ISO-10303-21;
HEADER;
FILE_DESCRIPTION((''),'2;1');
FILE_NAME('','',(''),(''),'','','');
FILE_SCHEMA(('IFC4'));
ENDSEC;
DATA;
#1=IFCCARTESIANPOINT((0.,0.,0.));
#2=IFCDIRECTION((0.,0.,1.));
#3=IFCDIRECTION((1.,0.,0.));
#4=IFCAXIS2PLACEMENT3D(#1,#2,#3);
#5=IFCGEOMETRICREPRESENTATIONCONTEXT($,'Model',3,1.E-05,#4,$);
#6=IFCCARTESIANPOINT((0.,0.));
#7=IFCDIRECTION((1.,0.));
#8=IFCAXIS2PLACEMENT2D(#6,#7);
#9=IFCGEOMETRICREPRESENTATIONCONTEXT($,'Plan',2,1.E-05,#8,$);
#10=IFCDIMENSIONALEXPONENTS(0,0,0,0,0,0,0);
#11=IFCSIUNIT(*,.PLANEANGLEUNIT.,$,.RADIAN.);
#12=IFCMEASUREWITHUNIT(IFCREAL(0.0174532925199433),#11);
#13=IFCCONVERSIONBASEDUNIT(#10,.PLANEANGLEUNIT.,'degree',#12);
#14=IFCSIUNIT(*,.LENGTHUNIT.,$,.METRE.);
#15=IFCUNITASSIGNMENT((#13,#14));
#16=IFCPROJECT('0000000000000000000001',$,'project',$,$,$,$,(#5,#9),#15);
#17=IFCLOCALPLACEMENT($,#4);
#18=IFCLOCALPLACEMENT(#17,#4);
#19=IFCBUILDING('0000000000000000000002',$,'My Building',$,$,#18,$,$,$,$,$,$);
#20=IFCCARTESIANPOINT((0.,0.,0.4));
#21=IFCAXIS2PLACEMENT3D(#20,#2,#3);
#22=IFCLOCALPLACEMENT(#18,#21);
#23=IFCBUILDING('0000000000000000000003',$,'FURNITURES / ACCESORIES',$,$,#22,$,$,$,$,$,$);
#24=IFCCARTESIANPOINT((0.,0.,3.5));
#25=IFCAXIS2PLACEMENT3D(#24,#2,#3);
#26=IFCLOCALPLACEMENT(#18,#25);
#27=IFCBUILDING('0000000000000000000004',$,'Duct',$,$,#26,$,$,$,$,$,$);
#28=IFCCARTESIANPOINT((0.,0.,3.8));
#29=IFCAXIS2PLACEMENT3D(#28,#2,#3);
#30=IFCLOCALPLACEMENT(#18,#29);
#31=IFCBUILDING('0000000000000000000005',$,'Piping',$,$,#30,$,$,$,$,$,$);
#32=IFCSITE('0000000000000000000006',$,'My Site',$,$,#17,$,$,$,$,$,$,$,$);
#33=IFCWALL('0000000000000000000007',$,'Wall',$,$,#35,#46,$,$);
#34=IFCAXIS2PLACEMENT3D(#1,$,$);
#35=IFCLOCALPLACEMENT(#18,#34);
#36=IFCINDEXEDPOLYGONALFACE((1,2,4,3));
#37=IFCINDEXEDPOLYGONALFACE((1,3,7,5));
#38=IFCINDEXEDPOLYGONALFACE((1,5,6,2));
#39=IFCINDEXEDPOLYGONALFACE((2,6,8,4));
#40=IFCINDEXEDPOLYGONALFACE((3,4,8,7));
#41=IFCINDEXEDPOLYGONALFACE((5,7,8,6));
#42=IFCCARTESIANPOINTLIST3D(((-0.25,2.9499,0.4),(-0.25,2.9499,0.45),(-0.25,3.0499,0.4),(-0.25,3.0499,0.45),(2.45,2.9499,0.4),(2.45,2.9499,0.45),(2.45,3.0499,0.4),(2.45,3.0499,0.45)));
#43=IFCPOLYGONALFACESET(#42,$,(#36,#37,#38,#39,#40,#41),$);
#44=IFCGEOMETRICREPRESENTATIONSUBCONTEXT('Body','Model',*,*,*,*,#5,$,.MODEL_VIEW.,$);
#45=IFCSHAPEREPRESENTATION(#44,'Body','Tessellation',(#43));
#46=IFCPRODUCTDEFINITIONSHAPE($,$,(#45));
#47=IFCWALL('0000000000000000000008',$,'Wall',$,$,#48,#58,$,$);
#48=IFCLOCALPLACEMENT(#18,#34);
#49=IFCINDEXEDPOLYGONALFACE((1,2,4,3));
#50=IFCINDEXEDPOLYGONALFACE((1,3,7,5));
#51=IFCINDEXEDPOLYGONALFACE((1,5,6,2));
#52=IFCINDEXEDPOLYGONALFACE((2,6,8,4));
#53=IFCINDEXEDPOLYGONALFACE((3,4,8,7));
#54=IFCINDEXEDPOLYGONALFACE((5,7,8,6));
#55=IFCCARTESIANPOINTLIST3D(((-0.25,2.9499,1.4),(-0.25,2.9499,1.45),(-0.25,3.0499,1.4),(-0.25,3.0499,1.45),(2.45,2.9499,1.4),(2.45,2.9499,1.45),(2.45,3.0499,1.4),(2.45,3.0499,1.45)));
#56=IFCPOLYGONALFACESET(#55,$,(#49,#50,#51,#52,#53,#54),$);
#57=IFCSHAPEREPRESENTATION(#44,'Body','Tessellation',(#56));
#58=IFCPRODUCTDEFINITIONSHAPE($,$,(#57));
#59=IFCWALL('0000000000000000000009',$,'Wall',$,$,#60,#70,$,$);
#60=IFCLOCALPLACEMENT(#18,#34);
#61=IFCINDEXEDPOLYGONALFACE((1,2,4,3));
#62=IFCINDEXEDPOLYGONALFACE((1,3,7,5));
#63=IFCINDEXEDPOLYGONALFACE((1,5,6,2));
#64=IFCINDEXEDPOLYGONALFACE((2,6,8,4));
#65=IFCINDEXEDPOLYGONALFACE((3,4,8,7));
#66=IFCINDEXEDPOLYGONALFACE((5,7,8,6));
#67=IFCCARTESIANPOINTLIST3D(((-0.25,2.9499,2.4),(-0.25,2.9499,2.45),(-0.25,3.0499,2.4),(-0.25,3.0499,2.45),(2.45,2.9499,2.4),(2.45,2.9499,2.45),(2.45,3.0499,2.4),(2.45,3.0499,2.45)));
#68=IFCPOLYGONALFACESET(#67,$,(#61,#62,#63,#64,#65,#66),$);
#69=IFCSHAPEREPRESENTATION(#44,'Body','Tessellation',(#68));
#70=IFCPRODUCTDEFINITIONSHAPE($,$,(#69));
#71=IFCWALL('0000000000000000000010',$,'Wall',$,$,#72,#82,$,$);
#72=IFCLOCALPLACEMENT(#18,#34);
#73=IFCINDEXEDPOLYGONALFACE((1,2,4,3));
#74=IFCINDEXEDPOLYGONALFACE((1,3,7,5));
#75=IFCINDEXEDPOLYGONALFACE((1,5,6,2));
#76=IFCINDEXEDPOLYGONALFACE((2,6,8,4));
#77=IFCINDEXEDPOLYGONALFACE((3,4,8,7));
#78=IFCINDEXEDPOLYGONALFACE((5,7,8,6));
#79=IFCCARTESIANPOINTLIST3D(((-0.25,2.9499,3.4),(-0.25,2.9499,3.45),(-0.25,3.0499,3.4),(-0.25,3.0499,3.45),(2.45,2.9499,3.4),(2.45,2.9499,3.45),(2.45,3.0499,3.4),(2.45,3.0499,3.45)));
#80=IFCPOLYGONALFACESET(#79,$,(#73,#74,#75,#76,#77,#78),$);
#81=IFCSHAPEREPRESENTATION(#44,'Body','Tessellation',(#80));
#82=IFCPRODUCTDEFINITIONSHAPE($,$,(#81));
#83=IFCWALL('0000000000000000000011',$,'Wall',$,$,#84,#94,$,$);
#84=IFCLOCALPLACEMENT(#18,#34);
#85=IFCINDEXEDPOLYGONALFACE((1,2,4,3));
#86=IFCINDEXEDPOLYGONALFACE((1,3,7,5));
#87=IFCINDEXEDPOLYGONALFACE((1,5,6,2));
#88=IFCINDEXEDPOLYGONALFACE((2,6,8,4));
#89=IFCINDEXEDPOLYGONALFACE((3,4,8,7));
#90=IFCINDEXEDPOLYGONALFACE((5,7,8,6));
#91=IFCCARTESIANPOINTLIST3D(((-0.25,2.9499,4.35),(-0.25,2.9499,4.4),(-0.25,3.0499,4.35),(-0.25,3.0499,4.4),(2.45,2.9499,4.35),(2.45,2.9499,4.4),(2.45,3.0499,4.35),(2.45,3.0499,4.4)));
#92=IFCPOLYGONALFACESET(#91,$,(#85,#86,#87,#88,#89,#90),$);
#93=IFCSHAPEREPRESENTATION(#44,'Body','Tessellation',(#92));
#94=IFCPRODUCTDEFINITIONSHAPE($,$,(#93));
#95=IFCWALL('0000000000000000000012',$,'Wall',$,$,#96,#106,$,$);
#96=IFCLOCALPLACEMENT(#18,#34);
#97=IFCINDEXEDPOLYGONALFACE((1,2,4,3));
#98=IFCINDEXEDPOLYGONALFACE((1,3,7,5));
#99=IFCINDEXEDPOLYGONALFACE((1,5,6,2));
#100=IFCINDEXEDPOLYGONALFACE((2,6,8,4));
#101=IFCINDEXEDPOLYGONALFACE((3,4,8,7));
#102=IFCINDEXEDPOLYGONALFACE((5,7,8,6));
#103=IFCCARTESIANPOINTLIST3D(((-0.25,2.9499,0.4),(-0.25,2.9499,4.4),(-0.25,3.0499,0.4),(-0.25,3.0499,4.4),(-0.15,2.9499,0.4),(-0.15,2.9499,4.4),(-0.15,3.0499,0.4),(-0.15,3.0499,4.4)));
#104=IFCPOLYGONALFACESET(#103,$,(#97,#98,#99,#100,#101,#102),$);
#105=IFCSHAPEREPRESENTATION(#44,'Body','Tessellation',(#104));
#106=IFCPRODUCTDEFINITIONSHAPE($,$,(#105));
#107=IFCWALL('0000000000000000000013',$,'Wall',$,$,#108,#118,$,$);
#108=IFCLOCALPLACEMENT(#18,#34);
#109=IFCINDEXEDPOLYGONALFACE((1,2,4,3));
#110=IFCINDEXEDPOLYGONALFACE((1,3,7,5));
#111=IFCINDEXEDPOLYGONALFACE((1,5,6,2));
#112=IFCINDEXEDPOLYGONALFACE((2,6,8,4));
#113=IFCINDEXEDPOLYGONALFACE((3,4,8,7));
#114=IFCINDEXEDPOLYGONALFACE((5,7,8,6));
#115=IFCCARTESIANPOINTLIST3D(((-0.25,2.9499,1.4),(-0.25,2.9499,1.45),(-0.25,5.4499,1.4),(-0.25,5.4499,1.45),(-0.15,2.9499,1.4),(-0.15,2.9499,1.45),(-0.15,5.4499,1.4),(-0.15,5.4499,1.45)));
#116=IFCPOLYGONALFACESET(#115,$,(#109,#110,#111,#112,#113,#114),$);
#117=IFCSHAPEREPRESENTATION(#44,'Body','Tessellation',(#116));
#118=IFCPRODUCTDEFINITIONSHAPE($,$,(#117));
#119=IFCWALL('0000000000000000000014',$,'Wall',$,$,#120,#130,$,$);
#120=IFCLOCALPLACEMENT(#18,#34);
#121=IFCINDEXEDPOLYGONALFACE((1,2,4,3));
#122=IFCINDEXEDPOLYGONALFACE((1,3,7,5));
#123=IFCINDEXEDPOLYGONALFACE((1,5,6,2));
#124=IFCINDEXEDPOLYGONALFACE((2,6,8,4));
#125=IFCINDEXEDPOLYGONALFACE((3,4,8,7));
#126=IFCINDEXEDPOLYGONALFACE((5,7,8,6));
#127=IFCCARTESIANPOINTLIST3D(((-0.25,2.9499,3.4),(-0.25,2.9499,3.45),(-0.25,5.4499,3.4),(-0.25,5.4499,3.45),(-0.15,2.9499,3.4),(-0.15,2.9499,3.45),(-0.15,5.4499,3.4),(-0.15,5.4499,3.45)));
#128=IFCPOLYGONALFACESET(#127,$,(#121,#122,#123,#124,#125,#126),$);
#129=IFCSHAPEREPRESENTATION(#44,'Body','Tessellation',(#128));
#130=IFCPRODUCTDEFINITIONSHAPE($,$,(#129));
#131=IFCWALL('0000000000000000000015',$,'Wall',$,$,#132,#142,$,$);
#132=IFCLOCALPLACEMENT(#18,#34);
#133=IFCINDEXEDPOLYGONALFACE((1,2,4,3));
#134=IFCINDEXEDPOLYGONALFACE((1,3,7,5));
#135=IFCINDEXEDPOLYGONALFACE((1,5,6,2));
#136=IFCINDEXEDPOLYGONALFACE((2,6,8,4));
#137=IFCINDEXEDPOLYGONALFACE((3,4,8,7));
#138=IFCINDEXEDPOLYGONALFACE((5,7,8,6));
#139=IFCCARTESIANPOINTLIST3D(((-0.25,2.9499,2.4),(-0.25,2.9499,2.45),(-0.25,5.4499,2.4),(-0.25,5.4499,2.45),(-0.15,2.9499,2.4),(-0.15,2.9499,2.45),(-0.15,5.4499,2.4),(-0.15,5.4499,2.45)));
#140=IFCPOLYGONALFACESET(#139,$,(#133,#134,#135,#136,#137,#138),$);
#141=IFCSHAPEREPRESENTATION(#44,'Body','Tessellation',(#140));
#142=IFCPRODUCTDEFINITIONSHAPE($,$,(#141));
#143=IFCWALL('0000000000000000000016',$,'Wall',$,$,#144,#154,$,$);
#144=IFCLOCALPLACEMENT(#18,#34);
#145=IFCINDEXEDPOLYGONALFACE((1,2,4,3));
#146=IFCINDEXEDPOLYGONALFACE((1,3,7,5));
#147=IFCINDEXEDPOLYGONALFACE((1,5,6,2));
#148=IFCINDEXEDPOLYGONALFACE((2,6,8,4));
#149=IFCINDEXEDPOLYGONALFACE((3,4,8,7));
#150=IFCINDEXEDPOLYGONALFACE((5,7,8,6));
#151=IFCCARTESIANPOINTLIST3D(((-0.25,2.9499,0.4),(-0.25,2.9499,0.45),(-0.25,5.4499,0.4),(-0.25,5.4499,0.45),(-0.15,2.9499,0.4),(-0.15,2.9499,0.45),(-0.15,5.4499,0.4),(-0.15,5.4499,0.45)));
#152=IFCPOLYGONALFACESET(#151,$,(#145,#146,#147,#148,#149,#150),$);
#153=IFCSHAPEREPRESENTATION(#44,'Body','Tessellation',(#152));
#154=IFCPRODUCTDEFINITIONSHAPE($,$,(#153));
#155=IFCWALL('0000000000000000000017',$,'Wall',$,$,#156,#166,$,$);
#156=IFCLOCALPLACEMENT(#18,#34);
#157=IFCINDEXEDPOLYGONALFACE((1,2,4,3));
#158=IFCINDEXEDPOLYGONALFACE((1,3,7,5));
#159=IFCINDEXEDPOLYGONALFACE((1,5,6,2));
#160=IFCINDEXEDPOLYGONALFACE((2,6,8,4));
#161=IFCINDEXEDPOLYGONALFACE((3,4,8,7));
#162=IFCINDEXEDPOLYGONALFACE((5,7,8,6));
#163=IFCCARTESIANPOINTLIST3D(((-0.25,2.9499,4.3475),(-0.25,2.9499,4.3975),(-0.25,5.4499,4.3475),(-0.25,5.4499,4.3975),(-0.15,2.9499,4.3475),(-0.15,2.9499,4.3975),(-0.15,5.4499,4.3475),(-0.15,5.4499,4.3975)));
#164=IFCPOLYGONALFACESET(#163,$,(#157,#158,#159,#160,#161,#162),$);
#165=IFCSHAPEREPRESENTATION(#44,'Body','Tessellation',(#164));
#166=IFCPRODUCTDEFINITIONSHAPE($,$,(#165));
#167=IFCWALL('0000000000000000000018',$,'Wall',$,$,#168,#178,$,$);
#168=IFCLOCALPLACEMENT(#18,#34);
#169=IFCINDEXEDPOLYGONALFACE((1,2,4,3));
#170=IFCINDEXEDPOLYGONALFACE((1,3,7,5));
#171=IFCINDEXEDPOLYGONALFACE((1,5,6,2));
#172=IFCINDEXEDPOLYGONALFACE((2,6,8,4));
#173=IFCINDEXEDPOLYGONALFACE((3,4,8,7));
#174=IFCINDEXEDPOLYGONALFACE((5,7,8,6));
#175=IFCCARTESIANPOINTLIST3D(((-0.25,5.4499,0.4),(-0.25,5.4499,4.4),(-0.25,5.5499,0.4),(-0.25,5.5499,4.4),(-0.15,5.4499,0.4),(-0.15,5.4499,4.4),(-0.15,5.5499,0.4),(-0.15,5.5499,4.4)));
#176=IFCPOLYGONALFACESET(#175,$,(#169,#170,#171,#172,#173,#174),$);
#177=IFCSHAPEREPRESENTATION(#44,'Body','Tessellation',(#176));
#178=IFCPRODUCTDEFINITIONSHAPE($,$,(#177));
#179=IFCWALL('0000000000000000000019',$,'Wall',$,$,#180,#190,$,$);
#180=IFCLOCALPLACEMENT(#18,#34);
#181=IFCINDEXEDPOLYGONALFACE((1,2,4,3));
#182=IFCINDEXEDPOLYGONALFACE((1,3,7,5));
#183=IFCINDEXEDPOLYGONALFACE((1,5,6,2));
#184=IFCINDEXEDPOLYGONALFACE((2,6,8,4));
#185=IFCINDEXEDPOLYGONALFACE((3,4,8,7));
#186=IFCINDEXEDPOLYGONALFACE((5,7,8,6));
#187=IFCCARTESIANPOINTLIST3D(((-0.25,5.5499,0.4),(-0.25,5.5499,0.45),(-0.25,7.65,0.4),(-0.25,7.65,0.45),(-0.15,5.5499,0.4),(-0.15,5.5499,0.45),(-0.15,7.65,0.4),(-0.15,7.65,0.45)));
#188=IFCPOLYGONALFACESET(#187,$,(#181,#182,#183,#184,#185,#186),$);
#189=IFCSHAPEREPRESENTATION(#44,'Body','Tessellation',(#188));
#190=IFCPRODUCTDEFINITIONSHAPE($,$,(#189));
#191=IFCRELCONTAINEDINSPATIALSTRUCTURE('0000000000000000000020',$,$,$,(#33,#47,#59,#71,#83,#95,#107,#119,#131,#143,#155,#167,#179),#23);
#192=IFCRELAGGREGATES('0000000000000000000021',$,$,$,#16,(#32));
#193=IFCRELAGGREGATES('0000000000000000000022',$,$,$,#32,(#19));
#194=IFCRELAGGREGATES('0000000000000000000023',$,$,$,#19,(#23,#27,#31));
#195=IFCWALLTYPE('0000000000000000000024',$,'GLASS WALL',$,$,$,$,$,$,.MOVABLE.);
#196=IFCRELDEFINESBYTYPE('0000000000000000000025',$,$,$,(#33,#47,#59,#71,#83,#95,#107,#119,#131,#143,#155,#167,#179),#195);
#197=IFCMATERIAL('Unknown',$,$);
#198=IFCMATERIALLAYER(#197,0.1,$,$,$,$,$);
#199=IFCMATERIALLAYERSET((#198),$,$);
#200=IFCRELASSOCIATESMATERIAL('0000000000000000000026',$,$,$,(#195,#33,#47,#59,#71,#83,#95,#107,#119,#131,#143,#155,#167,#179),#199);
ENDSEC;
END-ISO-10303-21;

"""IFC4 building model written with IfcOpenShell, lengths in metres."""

from ifc_helpers import new_model, entity, si_unit, converted_unit, frame, origin_with_axes, origin_2d_with_axis, place, context, subcontext, project, spatial, line, indexed_curve, outline, extrude, material, layer, layer_set, layer_usage, type_object, element, save


model = new_model("IFC4")

# Units and contexts
model_context = context("Model", 3, precision=1e-05, world=origin_with_axes())
plan_context = context("Plan", 2, precision=1e-05, world=origin_2d_with_axis())
body_context = subcontext(model_context, "Body", "Model", "MODEL_VIEW")
ifc_project = project(units=[converted_unit("PLANEANGLEUNIT", "degree", entity("IfcReal", 0.0174532925199433), si_unit("PLANEANGLEUNIT", "RADIAN"), dimensions=[0, 0, 0, 0, 0, 0, 0]), si_unit("LENGTHUNIT", "METRE")], contexts=[model_context, plan_context])

# Site, building
site_placement = place(None, origin_with_axes())
site = spatial("IfcSite", under=ifc_project, at=site_placement, Name="My Site")
building_1_placement = place(site_placement, origin_with_axes())
building_1 = spatial("IfcBuilding", under=site, at=building_1_placement, Name="My Building")

# Shared definitions
ifc_material = material(Name="Unknown")

# Shared definitions
building_2_placement = place(building_1_placement, frame((0.0, 0.0, 0.4), z_axis=(0.0, 0.0, 1.0), x_axis=(1.0, 0.0, 0.0)))
building_2 = spatial("IfcBuilding", under=building_1, at=building_2_placement, Name="FURNITURES / ACCESORIES")

# Walls
ifc_layer_1 = layer(ifc_material, 0.1)
ifc_layer_set_1 = layer_set([ifc_layer_1])
wall_type = type_object("IfcWallType", Name="GLASS WALL", PredefinedType="MOVABLE", material=ifc_layer_set_1)
ifc_layer_usage_1 = layer_usage(ifc_layer_set_1, "AXIS2", "POSITIVE", 0.0)
wall_1_placement = place(building_2_placement, frame((2.45, 3.0499, 0.0), z_axis=(0.0, 0.0, 1.0), x_axis=(-1.0, 0.0, 0.0)))
element("IfcWall", 1, at=wall_1_placement, inside=building_2, type_object=wall_type, material=ifc_layer_usage_1, Name="Wall", context=body_context, shape_type="SweptSolid", body=[
    extrude(outline(indexed_curve([(0.0, 0.0), (0.0, 0.1), (2.7, 0.1), (2.7, 0.0)], segments=[line(1, 2, 3, 4, 1)])), origin_with_axes(), (0.0, 0.0, 1.0), 0.05),
])
ifc_layer_usage_2 = layer_usage(ifc_layer_set_1, "AXIS2", "POSITIVE", 0.0)
wall_2_placement = place(building_2_placement, frame((2.45, 3.0499, 1.0), z_axis=(0.0, 0.0, 1.0), x_axis=(-1.0, 0.0, 0.0)))
element("IfcWall", 2, at=wall_2_placement, inside=building_2, type_object=wall_type, material=ifc_layer_usage_2, Name="Wall", context=body_context, shape_type="SweptSolid", body=[
    extrude(outline(indexed_curve([(0.0, 0.0), (0.0, 0.1), (2.7, 0.1), (2.7, 0.0)], segments=[line(1, 2, 3, 4, 1)])), origin_with_axes(), (0.0, 0.0, 1.0), 0.05),
])
ifc_layer_usage_3 = layer_usage(ifc_layer_set_1, "AXIS2", "POSITIVE", 0.0)
wall_3_placement = place(building_2_placement, frame((2.45, 3.0499, 2.0), z_axis=(0.0, 0.0, 1.0), x_axis=(-1.0, 0.0, 0.0)))
element("IfcWall", 3, at=wall_3_placement, inside=building_2, type_object=wall_type, material=ifc_layer_usage_3, Name="Wall", context=body_context, shape_type="SweptSolid", body=[
    extrude(outline(indexed_curve([(0.0, 0.0), (0.0, 0.1), (2.7, 0.1), (2.7, 0.0)], segments=[line(1, 2, 3, 4, 1)])), origin_with_axes(), (0.0, 0.0, 1.0), 0.05),
])
ifc_layer_usage_4 = layer_usage(ifc_layer_set_1, "AXIS2", "POSITIVE", 0.0)
wall_4_placement = place(building_2_placement, frame((2.45, 3.0499, 3.0), z_axis=(0.0, 0.0, 1.0), x_axis=(-1.0, 0.0, 0.0)))
element("IfcWall", 4, at=wall_4_placement, inside=building_2, type_object=wall_type, material=ifc_layer_usage_4, Name="Wall", context=body_context, shape_type="SweptSolid", body=[
    extrude(outline(indexed_curve([(0.0, 0.0), (0.0, 0.1), (2.7, 0.1), (2.7, 0.0)], segments=[line(1, 2, 3, 4, 1)])), origin_with_axes(), (0.0, 0.0, 1.0), 0.05),
])
ifc_layer_usage_5 = layer_usage(ifc_layer_set_1, "AXIS2", "POSITIVE", 0.0)
wall_5_placement = place(building_2_placement, frame((2.45, 3.0499, 3.95), z_axis=(0.0, 0.0, 1.0), x_axis=(-1.0, 0.0, 0.0)))
element("IfcWall", 5, at=wall_5_placement, inside=building_2, type_object=wall_type, material=ifc_layer_usage_5, Name="Wall", context=body_context, shape_type="SweptSolid", body=[
    extrude(outline(indexed_curve([(0.0, 0.0), (0.0, 0.1), (2.7, 0.1), (2.7, 0.0)], segments=[line(1, 2, 3, 4, 1)])), origin_with_axes(), (0.0, 0.0, 1.0), 0.05),
])
ifc_layer_usage_6 = layer_usage(ifc_layer_set_1, "AXIS2", "POSITIVE", 0.0)
wall_6_placement = place(building_2_placement, frame((-0.25, 2.9499, 0.0), z_axis=(0.0, 0.0, 1.0), x_axis=(1.0, 0.0, 0.0)))
element("IfcWall", 6, at=wall_6_placement, inside=building_2, type_object=wall_type, material=ifc_layer_usage_6, Name="Wall", context=body_context, shape_type="SweptSolid", body=[
    extrude(outline(indexed_curve([(0.0, 0.0), (0.0, 0.1), (0.1, 0.1), (0.1, 0.0)], segments=[line(1, 2, 3, 4, 1)])), origin_with_axes(), (0.0, 0.0, 1.0), 4.0),
])
ifc_layer_usage_7 = layer_usage(ifc_layer_set_1, "AXIS2", "POSITIVE", 0.0)
wall_7_placement = place(building_2_placement, frame((-0.25, 5.4499, 1.0), z_axis=(0.0, 0.0, 1.0), x_axis=(0.0, -1.0, 0.0)))
element("IfcWall", 7, at=wall_7_placement, inside=building_2, type_object=wall_type, material=ifc_layer_usage_7, Name="Wall", context=body_context, shape_type="SweptSolid", body=[
    extrude(outline(indexed_curve([(0.0, 0.0), (0.0, 0.1), (2.5, 0.1), (2.5, 0.0)], segments=[line(1, 2, 3, 4, 1)])), origin_with_axes(), (0.0, 0.0, 1.0), 0.05),
])
ifc_layer_usage_8 = layer_usage(ifc_layer_set_1, "AXIS2", "POSITIVE", 0.0)
wall_8_placement = place(building_2_placement, frame((-0.25, 5.4499, 3.0), z_axis=(0.0, 0.0, 1.0), x_axis=(0.0, -1.0, 0.0)))
element("IfcWall", 8, at=wall_8_placement, inside=building_2, type_object=wall_type, material=ifc_layer_usage_8, Name="Wall", context=body_context, shape_type="SweptSolid", body=[
    extrude(outline(indexed_curve([(0.0, 0.0), (0.0, 0.1), (2.5, 0.1), (2.5, 0.0)], segments=[line(1, 2, 3, 4, 1)])), origin_with_axes(), (0.0, 0.0, 1.0), 0.05),
])
ifc_layer_usage_9 = layer_usage(ifc_layer_set_1, "AXIS2", "POSITIVE", 0.0)
wall_9_placement = place(building_2_placement, frame((-0.25, 5.4499, 2.0), z_axis=(0.0, 0.0, 1.0), x_axis=(0.0, -1.0, 0.0)))
element("IfcWall", 9, at=wall_9_placement, inside=building_2, type_object=wall_type, material=ifc_layer_usage_9, Name="Wall", context=body_context, shape_type="SweptSolid", body=[
    extrude(outline(indexed_curve([(0.0, 0.0), (0.0, 0.1), (2.5, 0.1), (2.5, 0.0)], segments=[line(1, 2, 3, 4, 1)])), origin_with_axes(), (0.0, 0.0, 1.0), 0.05),
])
ifc_layer_usage_10 = layer_usage(ifc_layer_set_1, "AXIS2", "POSITIVE", 0.0)
wall_10_placement = place(building_2_placement, frame((-0.25, 5.4499, 0.0), z_axis=(0.0, 0.0, 1.0), x_axis=(0.0, -1.0, 0.0)))
element("IfcWall", 10, at=wall_10_placement, inside=building_2, type_object=wall_type, material=ifc_layer_usage_10, Name="Wall", context=body_context, shape_type="SweptSolid", body=[
    extrude(outline(indexed_curve([(0.0, 0.0), (0.0, 0.1), (2.5, 0.1), (2.5, 0.0)], segments=[line(1, 2, 3, 4, 1)])), origin_with_axes(), (0.0, 0.0, 1.0), 0.05),
])
ifc_layer_usage_11 = layer_usage(ifc_layer_set_1, "AXIS2", "POSITIVE", 0.0)
wall_11_placement = place(building_2_placement, frame((-0.25, 5.4499, 3.9475), z_axis=(0.0, 0.0, 1.0), x_axis=(0.0, -1.0, 0.0)))
element("IfcWall", 11, at=wall_11_placement, inside=building_2, type_object=wall_type, material=ifc_layer_usage_11, Name="Wall", context=body_context, shape_type="SweptSolid", body=[
    extrude(outline(indexed_curve([(0.0, 0.0), (0.0, 0.1), (2.5, 0.1), (2.5, 0.0)], segments=[line(1, 2, 3, 4, 1)])), origin_with_axes(), (0.0, 0.0, 1.0), 0.05),
])
ifc_layer_usage_12 = layer_usage(ifc_layer_set_1, "AXIS2", "POSITIVE", 0.0)
wall_12_placement = place(building_2_placement, frame((-0.25, 5.4499, 0.0), z_axis=(0.0, 0.0, 1.0), x_axis=(1.0, 0.0, 0.0)))
element("IfcWall", 12, at=wall_12_placement, inside=building_2, type_object=wall_type, material=ifc_layer_usage_12, Name="Wall", context=body_context, shape_type="SweptSolid", body=[
    extrude(outline(indexed_curve([(0.0, 0.0), (0.0, 0.1), (0.1, 0.1), (0.1, 0.0)], segments=[line(1, 2, 3, 4, 1)])), origin_with_axes(), (0.0, 0.0, 1.0), 4.0),
])
ifc_layer_usage_13 = layer_usage(ifc_layer_set_1, "AXIS2", "POSITIVE", 0.0)
wall_13_placement = place(building_2_placement, frame((-0.15, 5.5499, 0.0), z_axis=(0.0, 0.0, 1.0), x_axis=(0.0, 1.0, 0.0)))
element("IfcWall", 13, at=wall_13_placement, inside=building_2, type_object=wall_type, material=ifc_layer_usage_13, Name="Wall", context=body_context, shape_type="SweptSolid", body=[
    extrude(outline(indexed_curve([(0.0, 0.0), (0.0, 0.1), (2.1001, 0.1), (2.1001, 0.0)], segments=[line(1, 2, 3, 4, 1)])), origin_with_axes(), (0.0, 0.0, 1.0), 0.05),
])

# Shared definitions
building_3_placement = place(building_1_placement, frame((0.0, 0.0, 3.5), z_axis=(0.0, 0.0, 1.0), x_axis=(1.0, 0.0, 0.0)))
building_3 = spatial("IfcBuilding", under=building_1, at=building_3_placement, Name="Duct")

# Shared definitions
building_4_placement = place(building_1_placement, frame((0.0, 0.0, 3.8), z_axis=(0.0, 0.0, 1.0), x_axis=(1.0, 0.0, 0.0)))
building_4 = spatial("IfcBuilding", under=building_1, at=building_4_placement, Name="Piping")

save(model, "model.ifc")
